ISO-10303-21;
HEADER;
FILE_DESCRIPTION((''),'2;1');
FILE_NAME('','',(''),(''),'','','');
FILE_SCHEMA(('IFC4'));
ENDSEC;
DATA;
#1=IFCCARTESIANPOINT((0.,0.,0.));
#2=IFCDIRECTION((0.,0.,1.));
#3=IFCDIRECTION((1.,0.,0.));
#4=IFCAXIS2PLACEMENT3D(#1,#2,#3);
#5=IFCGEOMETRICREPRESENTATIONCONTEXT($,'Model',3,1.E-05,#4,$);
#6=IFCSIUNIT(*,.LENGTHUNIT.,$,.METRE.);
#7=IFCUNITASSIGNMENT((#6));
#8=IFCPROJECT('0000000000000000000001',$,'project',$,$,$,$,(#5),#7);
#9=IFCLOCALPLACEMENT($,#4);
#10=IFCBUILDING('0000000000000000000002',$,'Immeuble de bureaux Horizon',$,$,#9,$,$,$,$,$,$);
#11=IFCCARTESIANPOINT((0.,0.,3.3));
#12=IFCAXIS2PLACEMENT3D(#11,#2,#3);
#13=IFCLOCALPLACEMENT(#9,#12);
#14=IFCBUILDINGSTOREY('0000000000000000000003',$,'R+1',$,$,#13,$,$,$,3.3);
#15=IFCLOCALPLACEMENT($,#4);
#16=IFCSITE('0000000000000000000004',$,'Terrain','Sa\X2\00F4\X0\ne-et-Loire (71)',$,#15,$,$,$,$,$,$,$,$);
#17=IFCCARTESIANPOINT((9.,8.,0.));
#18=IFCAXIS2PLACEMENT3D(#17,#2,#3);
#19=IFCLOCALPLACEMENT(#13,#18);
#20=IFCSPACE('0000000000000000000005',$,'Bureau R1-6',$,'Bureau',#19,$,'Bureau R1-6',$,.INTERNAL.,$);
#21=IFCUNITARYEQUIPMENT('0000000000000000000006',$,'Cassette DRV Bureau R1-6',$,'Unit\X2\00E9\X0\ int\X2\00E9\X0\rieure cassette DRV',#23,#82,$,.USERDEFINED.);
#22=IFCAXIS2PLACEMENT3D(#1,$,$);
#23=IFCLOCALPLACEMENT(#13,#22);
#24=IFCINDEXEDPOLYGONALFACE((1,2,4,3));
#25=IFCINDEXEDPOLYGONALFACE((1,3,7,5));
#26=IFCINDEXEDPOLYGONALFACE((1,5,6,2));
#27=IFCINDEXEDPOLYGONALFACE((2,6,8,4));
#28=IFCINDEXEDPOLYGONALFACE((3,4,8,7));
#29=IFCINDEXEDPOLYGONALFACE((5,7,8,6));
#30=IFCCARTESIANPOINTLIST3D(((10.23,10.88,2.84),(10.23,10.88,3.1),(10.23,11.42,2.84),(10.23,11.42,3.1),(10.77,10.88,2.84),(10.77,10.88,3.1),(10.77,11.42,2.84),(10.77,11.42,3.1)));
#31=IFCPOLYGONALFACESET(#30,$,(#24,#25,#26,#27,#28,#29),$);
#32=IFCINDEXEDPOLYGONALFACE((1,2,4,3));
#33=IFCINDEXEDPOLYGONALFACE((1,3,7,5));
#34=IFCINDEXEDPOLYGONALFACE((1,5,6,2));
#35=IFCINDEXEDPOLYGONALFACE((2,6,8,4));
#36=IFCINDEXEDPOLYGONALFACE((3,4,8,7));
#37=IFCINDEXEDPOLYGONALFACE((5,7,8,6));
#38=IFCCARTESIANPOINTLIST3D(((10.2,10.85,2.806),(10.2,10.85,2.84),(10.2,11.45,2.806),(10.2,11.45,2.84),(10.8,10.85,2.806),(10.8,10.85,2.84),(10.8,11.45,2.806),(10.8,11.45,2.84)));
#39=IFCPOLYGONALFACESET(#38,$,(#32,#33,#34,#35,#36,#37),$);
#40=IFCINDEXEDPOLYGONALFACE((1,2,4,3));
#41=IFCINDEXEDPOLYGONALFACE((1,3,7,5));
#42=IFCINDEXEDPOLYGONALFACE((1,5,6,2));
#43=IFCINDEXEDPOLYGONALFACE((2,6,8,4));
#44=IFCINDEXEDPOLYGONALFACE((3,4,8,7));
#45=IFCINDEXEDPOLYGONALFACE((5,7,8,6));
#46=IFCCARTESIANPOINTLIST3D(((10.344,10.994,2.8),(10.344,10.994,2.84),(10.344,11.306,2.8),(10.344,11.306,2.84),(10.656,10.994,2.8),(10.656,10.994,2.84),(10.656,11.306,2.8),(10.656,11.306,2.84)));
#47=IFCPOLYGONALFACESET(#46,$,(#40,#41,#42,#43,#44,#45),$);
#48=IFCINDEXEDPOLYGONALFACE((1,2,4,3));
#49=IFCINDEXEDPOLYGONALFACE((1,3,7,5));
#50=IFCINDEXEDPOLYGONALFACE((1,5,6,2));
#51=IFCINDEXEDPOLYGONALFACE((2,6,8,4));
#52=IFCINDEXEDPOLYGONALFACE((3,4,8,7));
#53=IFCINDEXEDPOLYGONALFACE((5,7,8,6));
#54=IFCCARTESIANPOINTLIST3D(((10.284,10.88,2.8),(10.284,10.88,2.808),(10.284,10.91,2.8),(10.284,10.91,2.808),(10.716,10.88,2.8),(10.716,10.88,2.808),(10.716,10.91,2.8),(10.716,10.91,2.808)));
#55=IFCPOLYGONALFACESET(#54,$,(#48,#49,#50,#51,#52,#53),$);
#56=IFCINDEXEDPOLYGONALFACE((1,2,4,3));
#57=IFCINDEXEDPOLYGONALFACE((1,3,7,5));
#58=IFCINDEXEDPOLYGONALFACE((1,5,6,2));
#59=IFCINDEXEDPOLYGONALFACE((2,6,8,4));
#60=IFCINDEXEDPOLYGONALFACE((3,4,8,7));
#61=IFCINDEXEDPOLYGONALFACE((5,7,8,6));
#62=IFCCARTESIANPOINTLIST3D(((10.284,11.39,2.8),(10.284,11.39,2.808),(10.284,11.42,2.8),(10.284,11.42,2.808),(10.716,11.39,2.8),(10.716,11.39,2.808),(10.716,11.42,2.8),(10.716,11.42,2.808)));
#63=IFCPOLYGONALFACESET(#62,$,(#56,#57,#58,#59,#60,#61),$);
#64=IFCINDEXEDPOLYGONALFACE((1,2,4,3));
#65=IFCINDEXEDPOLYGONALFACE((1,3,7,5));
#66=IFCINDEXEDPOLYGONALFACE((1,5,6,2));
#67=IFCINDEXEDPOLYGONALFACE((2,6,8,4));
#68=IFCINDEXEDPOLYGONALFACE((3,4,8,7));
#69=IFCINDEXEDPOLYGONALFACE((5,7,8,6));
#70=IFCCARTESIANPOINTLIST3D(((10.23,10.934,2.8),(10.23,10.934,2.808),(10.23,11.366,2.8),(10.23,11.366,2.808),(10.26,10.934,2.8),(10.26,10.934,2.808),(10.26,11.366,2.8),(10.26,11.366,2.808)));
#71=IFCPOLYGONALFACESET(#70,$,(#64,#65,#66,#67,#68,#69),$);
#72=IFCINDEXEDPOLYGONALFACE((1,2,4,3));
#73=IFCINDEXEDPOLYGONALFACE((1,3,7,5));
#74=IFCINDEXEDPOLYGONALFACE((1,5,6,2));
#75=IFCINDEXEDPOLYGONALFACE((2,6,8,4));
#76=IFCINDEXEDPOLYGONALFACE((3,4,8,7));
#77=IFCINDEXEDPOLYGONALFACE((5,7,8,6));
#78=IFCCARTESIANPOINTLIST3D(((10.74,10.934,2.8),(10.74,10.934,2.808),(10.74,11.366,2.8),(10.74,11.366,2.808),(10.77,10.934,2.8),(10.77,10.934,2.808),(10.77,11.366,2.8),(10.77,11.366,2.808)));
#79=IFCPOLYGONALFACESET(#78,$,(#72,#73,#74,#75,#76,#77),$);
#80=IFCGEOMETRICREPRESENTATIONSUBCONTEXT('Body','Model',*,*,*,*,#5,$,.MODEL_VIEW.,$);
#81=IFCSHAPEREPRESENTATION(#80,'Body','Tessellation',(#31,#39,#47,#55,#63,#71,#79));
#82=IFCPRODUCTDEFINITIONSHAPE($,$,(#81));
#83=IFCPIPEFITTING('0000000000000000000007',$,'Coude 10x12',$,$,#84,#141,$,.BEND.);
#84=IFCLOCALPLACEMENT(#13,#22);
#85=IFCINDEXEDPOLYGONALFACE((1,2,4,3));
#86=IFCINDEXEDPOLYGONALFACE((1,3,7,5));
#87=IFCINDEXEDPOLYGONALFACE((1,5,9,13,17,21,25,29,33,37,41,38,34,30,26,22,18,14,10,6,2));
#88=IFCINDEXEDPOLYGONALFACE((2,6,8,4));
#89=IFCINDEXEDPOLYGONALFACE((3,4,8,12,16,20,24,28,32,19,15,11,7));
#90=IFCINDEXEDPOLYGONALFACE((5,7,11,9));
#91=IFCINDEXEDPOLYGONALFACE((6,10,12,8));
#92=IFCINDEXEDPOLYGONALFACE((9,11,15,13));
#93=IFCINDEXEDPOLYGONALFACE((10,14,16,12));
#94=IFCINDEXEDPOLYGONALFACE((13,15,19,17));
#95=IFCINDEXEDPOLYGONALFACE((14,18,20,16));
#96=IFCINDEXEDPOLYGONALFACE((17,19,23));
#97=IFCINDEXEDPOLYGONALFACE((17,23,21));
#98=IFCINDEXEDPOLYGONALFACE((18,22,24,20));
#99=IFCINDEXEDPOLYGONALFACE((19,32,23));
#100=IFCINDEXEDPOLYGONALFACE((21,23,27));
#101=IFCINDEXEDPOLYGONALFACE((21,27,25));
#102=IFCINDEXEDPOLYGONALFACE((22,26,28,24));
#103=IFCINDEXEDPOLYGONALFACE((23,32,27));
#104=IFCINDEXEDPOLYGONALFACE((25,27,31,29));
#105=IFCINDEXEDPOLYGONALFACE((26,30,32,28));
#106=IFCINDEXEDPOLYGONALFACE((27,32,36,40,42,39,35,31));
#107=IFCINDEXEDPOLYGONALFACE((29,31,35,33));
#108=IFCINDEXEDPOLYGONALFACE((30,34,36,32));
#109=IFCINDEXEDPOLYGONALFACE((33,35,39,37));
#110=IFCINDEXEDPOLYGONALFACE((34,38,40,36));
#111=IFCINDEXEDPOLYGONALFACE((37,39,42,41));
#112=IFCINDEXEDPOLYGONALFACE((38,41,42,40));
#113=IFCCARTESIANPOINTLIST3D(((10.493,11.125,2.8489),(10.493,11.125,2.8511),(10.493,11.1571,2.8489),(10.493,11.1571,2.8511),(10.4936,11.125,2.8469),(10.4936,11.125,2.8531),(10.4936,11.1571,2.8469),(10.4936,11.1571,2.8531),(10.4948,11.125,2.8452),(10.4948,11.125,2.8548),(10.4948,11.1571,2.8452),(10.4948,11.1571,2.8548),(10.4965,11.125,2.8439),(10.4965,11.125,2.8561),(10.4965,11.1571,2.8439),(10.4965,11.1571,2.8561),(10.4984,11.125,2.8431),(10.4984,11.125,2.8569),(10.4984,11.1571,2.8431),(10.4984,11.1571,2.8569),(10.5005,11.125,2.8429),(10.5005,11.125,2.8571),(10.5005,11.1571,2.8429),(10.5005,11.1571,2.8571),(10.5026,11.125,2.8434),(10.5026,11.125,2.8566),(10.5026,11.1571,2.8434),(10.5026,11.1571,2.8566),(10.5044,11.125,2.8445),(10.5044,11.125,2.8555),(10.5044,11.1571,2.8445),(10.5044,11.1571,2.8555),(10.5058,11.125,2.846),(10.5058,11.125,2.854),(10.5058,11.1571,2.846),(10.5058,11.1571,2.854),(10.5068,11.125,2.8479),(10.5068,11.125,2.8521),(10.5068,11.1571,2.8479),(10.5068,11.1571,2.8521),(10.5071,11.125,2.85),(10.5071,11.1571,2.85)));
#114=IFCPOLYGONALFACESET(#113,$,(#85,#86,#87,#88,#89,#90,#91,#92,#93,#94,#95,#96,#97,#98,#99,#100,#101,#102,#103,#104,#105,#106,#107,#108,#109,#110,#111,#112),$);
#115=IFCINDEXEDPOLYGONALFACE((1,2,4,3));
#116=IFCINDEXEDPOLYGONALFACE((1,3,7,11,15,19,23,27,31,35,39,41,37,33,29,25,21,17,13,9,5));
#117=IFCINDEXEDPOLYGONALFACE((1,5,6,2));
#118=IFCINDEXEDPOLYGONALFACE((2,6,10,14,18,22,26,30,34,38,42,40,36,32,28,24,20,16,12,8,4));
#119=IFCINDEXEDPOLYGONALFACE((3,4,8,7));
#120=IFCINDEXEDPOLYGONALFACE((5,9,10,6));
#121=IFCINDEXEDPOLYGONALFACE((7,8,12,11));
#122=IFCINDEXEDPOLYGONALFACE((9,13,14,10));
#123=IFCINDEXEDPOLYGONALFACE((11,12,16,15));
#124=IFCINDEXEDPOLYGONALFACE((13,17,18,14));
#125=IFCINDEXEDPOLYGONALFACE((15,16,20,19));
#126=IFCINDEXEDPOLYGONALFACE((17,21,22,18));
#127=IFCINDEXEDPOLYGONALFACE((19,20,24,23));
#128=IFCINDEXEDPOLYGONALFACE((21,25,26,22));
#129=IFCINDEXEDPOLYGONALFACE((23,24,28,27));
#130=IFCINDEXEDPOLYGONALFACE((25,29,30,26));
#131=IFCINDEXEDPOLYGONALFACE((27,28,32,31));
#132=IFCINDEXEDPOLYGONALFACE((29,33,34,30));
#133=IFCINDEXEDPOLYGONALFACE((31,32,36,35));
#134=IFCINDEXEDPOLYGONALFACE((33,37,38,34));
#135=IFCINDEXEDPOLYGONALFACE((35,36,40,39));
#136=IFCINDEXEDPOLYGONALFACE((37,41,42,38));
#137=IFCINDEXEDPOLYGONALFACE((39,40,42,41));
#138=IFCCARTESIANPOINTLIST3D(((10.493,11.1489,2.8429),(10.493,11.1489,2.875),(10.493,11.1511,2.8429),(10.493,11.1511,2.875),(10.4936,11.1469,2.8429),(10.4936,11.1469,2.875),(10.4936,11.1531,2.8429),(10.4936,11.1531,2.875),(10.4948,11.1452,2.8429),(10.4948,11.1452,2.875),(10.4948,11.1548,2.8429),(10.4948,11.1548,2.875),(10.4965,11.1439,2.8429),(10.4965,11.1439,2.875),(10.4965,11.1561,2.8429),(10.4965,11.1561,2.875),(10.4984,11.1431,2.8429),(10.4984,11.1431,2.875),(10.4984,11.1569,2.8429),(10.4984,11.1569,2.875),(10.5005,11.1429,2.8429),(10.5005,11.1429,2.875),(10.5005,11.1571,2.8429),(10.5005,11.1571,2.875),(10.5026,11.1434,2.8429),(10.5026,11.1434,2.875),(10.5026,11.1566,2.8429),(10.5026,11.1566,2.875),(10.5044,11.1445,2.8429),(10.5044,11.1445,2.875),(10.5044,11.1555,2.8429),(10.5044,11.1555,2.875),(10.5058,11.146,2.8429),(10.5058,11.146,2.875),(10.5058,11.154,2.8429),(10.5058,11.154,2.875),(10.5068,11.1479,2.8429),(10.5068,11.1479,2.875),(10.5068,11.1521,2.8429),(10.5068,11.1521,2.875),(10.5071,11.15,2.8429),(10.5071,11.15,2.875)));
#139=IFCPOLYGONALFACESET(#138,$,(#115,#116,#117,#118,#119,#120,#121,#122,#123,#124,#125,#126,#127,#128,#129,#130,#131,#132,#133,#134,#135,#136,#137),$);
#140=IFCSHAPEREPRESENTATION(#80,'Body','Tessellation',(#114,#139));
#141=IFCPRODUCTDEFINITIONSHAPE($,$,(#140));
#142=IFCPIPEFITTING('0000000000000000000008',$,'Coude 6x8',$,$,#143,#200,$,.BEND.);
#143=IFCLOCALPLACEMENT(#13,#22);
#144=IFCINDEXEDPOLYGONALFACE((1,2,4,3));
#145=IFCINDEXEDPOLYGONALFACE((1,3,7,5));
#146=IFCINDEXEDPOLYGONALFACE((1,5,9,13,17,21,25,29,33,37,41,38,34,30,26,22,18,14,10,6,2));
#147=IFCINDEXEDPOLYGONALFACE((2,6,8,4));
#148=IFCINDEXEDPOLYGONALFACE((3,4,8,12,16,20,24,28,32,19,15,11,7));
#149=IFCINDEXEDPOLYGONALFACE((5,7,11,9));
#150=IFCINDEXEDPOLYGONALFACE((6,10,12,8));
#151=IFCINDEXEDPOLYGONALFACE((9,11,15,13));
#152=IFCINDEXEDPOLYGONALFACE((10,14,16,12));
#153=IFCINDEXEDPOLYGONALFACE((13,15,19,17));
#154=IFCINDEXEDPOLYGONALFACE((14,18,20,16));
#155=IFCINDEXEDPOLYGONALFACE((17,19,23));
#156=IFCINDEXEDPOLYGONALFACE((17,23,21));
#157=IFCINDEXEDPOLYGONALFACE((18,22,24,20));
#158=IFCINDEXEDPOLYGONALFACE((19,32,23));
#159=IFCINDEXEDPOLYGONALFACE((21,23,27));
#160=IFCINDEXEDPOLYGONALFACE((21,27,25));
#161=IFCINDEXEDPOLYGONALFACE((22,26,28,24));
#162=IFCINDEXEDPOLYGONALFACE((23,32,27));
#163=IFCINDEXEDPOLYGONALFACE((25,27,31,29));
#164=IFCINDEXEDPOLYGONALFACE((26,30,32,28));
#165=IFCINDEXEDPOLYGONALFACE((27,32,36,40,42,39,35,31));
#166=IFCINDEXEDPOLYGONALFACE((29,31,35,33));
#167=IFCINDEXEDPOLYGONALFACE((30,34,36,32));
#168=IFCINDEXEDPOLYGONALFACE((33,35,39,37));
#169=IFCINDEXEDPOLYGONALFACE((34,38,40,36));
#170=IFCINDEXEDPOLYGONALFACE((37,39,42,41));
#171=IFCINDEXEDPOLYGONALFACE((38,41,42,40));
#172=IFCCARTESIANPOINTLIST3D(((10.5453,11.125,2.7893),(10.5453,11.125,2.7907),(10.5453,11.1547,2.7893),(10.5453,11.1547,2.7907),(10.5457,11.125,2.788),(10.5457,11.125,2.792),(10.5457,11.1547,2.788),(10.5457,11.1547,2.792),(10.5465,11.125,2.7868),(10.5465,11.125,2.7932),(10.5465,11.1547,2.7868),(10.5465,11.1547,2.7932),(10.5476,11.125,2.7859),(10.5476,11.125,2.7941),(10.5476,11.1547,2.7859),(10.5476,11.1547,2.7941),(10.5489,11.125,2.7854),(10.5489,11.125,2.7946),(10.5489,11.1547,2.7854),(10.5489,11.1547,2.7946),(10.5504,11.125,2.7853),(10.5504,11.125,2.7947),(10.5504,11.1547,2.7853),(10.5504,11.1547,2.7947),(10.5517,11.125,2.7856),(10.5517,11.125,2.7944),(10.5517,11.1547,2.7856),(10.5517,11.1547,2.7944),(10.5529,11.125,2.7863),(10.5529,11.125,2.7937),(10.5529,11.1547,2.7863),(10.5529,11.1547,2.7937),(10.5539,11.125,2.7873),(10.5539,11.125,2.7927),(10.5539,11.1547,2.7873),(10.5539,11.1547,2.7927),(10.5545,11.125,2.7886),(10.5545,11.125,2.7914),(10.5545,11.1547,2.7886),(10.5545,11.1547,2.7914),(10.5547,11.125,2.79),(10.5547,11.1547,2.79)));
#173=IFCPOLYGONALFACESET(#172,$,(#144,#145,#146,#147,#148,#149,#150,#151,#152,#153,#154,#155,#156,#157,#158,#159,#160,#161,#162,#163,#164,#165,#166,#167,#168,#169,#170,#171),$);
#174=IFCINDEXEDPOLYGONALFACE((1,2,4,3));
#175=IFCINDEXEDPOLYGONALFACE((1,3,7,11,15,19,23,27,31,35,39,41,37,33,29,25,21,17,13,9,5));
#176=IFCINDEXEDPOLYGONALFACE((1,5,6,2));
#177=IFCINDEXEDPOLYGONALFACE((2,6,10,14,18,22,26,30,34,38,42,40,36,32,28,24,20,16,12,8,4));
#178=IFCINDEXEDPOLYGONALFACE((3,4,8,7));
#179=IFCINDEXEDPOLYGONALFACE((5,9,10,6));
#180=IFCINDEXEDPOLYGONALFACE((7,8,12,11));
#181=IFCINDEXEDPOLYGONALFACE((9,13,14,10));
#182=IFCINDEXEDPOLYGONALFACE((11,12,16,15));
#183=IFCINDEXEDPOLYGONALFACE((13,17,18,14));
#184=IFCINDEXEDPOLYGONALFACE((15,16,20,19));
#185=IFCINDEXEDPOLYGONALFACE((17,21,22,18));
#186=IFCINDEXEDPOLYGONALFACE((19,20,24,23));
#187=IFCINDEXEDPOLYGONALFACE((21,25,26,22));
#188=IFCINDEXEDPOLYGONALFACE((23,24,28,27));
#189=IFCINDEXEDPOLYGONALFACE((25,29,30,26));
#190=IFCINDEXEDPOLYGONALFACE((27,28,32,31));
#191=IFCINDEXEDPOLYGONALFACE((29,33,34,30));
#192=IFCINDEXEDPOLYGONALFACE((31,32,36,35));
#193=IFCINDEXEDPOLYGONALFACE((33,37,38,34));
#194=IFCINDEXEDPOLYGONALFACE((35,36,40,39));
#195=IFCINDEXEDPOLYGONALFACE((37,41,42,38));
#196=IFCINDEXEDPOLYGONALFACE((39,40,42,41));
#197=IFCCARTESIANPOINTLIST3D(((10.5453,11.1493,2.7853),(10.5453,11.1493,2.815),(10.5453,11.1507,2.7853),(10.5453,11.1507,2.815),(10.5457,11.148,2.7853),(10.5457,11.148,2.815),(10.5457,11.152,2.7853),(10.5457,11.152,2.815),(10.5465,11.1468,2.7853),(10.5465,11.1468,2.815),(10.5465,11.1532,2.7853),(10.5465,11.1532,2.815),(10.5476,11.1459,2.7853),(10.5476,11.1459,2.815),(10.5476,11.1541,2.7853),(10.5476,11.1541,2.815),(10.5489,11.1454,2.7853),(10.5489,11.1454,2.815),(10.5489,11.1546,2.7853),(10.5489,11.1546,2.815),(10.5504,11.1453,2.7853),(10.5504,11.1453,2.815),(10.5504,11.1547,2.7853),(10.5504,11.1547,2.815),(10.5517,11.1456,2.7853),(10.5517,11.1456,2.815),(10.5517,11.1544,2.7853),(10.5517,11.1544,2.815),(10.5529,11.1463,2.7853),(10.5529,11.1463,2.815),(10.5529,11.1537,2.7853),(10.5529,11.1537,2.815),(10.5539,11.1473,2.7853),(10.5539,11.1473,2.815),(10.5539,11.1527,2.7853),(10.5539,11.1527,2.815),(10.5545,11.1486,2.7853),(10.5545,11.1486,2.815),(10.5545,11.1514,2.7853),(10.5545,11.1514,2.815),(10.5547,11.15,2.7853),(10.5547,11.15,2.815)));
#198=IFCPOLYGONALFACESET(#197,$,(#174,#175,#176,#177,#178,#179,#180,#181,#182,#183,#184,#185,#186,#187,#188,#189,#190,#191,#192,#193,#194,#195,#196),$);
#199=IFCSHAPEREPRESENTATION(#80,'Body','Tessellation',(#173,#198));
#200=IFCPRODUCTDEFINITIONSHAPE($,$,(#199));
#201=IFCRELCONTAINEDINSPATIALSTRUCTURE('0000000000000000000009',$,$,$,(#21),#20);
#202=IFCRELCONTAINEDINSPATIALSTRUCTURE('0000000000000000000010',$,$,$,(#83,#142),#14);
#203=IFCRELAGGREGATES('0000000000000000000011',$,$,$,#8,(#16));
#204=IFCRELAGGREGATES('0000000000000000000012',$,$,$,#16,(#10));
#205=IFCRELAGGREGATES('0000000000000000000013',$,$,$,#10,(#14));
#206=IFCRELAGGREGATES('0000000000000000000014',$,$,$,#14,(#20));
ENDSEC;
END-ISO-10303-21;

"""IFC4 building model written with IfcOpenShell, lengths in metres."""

from ifc_helpers import new_model, si_unit, frame, frame_2d, origin_with_axes, place, context, subcontext, project, spatial, rectangle, circle, extrude, element, save


model = new_model("IFC4")

# Units and contexts
model_context = context("Model", 3, precision=1e-05, world=origin_with_axes())
body_context = subcontext(model_context, "Body", "Model", "MODEL_VIEW")
ifc_project = project(units=[si_unit("LENGTHUNIT", "METRE")], contexts=[model_context])

# Site, building, storey
site_placement = place(None, origin_with_axes())
site = spatial("IfcSite", under=ifc_project, at=site_placement, Name="Terrain", Description="Saône-et-Loire (71)")
building_placement = place(None, origin_with_axes())
building = spatial("IfcBuilding", under=site, at=building_placement, Name="Immeuble de bureaux Horizon")
storey_placement = place(building_placement, frame((0.0, 0.0, 3.3), z_axis=(0.0, 0.0, 1.0), x_axis=(1.0, 0.0, 0.0)))
storey = spatial("IfcBuildingStorey", under=building, at=storey_placement, Name="R+1", Elevation=3.3)

# Shared definitions
space_1_placement = place(storey_placement, frame((9.0, 8.0, 0.0), z_axis=(0.0, 0.0, 1.0), x_axis=(1.0, 0.0, 0.0)))
space_1 = spatial("IfcSpace", under=storey, at=space_1_placement, Name="Bureau R1-6", ObjectType="Bureau", LongName="Bureau R1-6", PredefinedType="INTERNAL")

# Unitary equipment
unitary_equipment_1_placement = place(space_1_placement, frame((1.2, 2.85, 2.8), z_axis=(0.0, 0.0, 1.0), x_axis=(1.0, 0.0, 0.0)))
element("IfcUnitaryEquipment", 1, at=unitary_equipment_1_placement, inside=space_1, Name="Cassette DRV Bureau R1-6", ObjectType="Unité intérieure cassette DRV", PredefinedType="USERDEFINED", context=body_context, shape_type="SweptSolid", body=[
    extrude(rectangle(XDim=0.54, YDim=0.54, at=frame_2d((0.27, 0.27))), frame((0.03, 0.03, 0.04), z_axis=(0.0, 0.0, 1.0), x_axis=(1.0, 0.0, 0.0)), (0.0, 0.0, 1.0), 0.26),
    extrude(rectangle(XDim=0.6, YDim=0.6, at=frame_2d((0.3, 0.3))), frame((0.0, 0.0, 0.006), z_axis=(0.0, 0.0, 1.0), x_axis=(1.0, 0.0, 0.0)), (0.0, 0.0, 1.0), 0.034),
    extrude(rectangle(XDim=0.312, YDim=0.312, at=frame_2d((0.156, 0.156))), frame((0.144, 0.144, 0.0), z_axis=(0.0, 0.0, 1.0), x_axis=(1.0, 0.0, 0.0)), (0.0, 0.0, 1.0), 0.04),
    extrude(rectangle(XDim=0.432, YDim=0.03, at=frame_2d((0.216, 0.015))), frame((0.084, 0.03, 0.0), z_axis=(0.0, 0.0, 1.0), x_axis=(1.0, 0.0, 0.0)), (0.0, 0.0, 1.0), 0.008),
    extrude(rectangle(XDim=0.432, YDim=0.03, at=frame_2d((0.216, 0.015))), frame((0.084, 0.54, 0.0), z_axis=(0.0, 0.0, 1.0), x_axis=(1.0, 0.0, 0.0)), (0.0, 0.0, 1.0), 0.008),
    extrude(rectangle(XDim=0.03, YDim=0.432, at=frame_2d((0.015, 0.216))), frame((0.03, 0.084, 0.0), z_axis=(0.0, 0.0, 1.0), x_axis=(1.0, 0.0, 0.0)), (0.0, 0.0, 1.0), 0.008),
    extrude(rectangle(XDim=0.03, YDim=0.432, at=frame_2d((0.015, 0.216))), frame((0.54, 0.084, 0.0), z_axis=(0.0, 0.0, 1.0), x_axis=(1.0, 0.0, 0.0)), (0.0, 0.0, 1.0), 0.008),
])

# Pipe fittings
pipe_fitting_1_placement = place(storey_placement, frame((10.5, 11.15, 2.85), z_axis=(0.0, 0.0, 1.0), x_axis=(1.0, 0.0, 0.0)))
element("IfcPipeFitting", 2, at=pipe_fitting_1_placement, inside=storey, Name="Coude 10x12", PredefinedType="BEND", context=body_context, shape_type="SweptSolid", body=[
    extrude(circle(Radius=0.0071), frame((0.0, 0.0071, 0.0), z_axis=(0.0, -1.0, 0.0), x_axis=(1.0, 0.0, 0.0)), (0.0, 0.0, 1.0), 0.0321),
    extrude(circle(Radius=0.0071), frame((0.0, 0.0, -0.0071), z_axis=(0.0, 0.0, 1.0), x_axis=(1.0, 0.0, 0.0)), (0.0, 0.0, 1.0), 0.0321),
])
pipe_fitting_2_placement = place(storey_placement, frame((10.55, 11.15, 2.79), z_axis=(0.0, 0.0, 1.0), x_axis=(1.0, 0.0, 0.0)))
element("IfcPipeFitting", 3, at=pipe_fitting_2_placement, inside=storey, Name="Coude 6x8", PredefinedType="BEND", context=body_context, shape_type="SweptSolid", body=[
    extrude(circle(Radius=0.0047), frame((0.0, 0.0047, 0.0), z_axis=(0.0, -1.0, 0.0), x_axis=(1.0, 0.0, 0.0)), (0.0, 0.0, 1.0), 0.0297),
    extrude(circle(Radius=0.0047), frame((0.0, 0.0, -0.0047), z_axis=(0.0, 0.0, 1.0), x_axis=(1.0, 0.0, 0.0)), (0.0, 0.0, 1.0), 0.0297),
])

save(model, "model.ifc")
